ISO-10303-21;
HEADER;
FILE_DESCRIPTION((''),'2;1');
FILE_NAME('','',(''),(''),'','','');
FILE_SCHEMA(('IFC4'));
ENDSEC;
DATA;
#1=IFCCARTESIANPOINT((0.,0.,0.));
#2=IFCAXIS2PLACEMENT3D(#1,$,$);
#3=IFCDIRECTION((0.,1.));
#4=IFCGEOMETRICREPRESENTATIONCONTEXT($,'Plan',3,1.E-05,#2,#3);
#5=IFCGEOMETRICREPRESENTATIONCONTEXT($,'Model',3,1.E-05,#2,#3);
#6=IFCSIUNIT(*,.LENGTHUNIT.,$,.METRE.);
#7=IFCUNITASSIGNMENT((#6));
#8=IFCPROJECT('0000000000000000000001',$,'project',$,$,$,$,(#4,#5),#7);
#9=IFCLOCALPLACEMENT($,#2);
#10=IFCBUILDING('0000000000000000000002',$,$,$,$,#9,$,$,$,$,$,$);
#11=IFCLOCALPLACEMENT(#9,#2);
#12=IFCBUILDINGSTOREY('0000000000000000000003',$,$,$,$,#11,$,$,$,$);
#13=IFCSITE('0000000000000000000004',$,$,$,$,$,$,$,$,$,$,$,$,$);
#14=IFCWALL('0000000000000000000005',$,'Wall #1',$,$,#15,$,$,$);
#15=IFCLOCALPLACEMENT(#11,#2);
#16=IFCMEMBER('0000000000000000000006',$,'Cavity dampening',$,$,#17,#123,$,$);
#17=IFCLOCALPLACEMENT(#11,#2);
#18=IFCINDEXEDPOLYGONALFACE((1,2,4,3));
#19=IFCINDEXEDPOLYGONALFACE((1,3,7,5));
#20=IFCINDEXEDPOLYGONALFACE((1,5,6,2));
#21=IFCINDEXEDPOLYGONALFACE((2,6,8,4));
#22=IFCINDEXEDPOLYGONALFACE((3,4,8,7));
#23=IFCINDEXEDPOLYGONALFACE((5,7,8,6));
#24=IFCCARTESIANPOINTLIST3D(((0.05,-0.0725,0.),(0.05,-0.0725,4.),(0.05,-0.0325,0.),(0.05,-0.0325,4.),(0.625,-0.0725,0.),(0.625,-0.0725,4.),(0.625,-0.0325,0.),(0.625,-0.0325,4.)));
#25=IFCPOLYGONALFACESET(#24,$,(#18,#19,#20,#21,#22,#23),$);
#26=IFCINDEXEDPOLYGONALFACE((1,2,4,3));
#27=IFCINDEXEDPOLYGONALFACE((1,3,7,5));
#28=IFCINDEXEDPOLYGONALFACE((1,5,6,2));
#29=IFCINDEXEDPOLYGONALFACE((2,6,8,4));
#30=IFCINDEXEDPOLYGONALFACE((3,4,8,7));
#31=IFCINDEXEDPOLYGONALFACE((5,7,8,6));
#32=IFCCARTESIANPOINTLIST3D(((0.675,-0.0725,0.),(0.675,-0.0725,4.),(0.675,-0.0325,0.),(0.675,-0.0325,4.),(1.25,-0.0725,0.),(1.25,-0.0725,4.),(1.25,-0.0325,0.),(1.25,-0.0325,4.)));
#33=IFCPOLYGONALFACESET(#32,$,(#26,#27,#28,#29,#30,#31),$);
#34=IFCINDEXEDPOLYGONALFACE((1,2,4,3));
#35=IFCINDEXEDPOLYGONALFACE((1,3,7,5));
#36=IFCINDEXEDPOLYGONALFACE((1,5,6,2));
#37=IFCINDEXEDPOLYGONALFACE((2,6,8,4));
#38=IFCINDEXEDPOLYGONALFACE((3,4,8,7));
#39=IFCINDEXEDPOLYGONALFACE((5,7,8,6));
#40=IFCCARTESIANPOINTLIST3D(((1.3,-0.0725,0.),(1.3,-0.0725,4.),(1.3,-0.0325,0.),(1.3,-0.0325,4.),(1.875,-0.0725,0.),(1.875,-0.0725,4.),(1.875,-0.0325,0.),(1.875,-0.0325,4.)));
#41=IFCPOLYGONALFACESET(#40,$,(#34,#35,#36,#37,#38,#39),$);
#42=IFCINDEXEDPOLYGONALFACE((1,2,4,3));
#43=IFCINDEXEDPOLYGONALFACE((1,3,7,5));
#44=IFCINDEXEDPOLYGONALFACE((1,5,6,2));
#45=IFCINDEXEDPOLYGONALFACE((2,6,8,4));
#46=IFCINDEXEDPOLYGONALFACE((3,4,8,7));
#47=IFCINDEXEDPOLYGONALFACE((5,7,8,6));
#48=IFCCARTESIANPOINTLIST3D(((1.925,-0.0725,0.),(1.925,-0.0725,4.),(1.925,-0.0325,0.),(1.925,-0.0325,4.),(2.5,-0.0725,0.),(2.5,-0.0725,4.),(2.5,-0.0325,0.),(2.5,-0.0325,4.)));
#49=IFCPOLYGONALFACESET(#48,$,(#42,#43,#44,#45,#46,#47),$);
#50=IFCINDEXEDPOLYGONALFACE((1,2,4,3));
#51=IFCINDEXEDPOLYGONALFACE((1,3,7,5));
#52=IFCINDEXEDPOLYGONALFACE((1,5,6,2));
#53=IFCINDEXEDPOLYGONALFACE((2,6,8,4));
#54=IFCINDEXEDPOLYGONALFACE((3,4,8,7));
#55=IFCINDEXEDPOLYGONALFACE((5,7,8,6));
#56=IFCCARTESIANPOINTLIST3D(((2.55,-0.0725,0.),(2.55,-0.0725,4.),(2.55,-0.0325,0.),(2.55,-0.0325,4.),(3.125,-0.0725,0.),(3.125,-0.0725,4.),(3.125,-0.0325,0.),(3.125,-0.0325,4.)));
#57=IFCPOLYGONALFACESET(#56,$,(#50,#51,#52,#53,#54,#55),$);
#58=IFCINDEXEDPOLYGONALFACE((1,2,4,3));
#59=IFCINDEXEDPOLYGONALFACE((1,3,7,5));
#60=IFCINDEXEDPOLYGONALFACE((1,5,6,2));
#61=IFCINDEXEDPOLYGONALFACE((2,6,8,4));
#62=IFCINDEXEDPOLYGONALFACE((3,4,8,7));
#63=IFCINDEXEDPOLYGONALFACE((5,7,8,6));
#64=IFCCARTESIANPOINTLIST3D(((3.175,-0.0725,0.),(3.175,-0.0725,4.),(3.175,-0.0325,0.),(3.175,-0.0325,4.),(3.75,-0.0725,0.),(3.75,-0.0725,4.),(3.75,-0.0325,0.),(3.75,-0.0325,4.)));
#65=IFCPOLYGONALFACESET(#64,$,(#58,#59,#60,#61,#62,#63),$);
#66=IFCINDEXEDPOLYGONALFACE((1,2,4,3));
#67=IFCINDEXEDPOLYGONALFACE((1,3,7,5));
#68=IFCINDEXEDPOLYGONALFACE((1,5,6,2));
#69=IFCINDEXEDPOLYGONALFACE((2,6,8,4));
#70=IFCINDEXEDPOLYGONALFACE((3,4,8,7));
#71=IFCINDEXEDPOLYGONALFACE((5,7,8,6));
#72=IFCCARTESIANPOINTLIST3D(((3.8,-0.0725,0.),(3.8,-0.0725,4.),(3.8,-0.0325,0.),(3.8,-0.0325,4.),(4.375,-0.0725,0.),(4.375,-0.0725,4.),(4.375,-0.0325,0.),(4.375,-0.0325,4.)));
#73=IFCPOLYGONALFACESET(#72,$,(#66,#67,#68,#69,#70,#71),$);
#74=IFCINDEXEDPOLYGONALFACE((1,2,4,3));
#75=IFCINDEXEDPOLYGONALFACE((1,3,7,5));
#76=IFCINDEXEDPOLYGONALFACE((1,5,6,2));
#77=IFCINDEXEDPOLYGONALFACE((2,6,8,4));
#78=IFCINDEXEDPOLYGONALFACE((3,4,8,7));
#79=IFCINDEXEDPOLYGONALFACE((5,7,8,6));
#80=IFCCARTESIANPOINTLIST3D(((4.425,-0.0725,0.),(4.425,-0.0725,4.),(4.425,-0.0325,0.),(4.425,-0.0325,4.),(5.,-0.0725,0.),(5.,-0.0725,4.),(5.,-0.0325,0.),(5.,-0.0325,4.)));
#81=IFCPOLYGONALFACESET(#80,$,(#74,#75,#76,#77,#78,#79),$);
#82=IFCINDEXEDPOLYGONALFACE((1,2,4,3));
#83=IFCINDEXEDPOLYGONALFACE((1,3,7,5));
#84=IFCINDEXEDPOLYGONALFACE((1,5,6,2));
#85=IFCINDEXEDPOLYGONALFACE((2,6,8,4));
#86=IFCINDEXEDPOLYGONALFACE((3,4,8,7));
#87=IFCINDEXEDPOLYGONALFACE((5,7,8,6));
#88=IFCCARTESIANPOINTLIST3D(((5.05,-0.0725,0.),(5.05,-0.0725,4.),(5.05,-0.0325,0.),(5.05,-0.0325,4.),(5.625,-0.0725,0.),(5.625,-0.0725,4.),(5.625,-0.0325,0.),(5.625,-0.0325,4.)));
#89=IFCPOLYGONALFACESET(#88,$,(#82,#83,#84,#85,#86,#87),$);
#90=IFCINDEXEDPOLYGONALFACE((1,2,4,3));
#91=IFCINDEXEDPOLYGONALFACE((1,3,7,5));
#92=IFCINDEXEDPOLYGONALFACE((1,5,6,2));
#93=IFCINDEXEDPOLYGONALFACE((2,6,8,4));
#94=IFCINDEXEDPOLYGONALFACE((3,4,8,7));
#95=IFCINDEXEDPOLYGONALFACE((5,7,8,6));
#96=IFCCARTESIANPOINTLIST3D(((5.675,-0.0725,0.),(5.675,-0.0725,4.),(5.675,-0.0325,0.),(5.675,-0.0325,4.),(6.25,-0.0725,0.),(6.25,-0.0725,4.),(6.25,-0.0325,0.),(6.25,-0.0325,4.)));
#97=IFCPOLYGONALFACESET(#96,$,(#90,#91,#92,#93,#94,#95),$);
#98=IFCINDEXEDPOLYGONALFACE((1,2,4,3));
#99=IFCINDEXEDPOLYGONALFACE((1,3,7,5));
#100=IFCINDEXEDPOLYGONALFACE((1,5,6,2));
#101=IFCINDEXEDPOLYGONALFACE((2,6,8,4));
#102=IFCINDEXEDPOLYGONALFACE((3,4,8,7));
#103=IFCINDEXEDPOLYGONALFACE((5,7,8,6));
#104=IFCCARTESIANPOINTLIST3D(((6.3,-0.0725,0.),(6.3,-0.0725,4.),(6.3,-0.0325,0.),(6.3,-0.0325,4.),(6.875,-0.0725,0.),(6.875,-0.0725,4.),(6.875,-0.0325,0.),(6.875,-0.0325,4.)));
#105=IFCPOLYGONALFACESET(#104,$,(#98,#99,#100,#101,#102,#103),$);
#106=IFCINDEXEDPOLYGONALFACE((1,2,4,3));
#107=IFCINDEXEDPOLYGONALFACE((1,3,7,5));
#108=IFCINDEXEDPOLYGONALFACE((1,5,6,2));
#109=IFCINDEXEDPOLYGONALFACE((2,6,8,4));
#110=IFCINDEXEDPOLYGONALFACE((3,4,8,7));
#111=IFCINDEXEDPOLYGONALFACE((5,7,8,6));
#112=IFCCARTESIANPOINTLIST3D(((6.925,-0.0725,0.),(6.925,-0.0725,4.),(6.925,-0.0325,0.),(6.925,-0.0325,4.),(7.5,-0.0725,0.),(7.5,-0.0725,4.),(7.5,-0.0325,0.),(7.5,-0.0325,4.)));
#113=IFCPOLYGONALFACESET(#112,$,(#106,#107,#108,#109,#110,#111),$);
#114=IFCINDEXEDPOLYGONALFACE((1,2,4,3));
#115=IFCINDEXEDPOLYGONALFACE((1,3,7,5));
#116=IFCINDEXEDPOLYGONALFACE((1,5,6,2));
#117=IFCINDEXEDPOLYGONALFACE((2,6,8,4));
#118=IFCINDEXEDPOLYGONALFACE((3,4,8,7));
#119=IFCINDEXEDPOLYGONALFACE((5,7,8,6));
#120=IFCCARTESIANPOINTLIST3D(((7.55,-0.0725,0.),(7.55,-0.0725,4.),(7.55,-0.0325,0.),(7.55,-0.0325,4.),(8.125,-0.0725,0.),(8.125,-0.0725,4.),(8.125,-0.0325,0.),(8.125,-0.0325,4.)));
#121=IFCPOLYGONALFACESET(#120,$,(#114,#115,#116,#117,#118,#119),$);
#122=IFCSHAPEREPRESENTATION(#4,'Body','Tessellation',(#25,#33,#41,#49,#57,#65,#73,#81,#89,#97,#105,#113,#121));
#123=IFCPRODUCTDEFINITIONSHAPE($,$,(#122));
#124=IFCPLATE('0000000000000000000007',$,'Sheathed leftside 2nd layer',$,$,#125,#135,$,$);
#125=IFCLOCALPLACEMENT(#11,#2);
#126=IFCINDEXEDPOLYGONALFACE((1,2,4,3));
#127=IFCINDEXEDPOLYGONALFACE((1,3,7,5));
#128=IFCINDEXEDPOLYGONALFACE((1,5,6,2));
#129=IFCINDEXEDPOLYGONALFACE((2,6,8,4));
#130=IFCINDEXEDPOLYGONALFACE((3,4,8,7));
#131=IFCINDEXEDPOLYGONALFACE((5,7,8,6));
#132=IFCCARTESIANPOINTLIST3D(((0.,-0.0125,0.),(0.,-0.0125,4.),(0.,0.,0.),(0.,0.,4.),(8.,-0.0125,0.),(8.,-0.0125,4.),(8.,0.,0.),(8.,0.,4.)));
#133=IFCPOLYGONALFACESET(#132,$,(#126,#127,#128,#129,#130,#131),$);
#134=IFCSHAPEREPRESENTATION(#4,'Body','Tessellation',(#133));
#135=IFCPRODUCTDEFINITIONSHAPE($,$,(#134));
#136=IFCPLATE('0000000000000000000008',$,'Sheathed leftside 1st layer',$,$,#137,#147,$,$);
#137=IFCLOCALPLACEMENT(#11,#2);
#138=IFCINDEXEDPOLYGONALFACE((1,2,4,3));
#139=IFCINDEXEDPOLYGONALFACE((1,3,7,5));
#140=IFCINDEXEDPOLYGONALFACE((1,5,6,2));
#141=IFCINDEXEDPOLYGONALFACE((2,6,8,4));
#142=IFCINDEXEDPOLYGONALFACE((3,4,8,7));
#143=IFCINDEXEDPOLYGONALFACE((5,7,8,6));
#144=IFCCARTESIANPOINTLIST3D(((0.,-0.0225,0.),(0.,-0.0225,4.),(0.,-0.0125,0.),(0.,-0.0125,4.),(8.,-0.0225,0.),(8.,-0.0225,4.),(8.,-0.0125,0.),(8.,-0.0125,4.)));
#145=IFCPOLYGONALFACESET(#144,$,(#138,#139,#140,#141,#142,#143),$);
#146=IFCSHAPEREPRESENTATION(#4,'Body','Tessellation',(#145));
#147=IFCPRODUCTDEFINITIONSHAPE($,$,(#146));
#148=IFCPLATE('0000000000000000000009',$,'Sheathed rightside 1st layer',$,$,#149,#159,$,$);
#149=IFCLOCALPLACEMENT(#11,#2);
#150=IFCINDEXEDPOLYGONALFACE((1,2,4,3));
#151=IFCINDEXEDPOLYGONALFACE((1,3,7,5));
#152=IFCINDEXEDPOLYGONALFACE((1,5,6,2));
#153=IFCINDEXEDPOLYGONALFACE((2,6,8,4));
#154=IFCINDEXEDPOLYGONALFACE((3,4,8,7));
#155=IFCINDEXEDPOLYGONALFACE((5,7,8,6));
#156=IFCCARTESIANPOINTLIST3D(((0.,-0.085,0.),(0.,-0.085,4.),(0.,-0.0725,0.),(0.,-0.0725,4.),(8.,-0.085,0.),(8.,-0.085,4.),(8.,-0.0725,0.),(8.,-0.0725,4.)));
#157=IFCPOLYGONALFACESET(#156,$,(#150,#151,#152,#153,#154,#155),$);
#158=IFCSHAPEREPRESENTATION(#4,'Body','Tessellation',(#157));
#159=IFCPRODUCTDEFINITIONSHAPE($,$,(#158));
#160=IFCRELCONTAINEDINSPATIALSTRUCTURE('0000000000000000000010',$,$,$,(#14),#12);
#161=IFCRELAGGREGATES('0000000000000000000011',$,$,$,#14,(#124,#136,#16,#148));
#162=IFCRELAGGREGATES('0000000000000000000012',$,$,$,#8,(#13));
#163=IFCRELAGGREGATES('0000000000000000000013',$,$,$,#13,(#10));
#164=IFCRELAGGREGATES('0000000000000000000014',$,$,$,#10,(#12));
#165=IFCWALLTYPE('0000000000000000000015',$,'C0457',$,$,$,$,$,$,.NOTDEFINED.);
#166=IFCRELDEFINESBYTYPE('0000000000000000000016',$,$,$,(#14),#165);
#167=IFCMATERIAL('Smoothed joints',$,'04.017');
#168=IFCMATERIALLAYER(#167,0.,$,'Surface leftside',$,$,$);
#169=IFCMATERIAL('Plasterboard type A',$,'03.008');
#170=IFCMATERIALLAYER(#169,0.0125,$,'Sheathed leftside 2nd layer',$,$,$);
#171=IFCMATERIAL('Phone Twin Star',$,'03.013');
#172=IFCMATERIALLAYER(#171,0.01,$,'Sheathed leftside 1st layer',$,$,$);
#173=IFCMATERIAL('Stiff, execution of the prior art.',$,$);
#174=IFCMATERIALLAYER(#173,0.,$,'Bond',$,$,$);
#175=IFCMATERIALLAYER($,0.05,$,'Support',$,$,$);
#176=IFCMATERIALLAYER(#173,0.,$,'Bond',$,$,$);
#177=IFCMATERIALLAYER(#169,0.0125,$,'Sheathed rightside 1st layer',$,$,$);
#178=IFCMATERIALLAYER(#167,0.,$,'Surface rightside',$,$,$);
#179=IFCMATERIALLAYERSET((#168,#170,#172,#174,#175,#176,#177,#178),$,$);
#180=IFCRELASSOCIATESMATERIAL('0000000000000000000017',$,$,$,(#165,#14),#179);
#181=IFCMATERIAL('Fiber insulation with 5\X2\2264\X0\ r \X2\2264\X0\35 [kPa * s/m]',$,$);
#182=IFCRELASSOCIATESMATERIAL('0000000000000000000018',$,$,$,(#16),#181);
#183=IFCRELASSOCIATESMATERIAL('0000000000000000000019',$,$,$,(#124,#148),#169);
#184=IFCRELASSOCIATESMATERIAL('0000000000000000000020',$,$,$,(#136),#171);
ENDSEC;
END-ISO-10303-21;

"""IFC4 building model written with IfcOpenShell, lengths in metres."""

from ifc_helpers import new_model, si_unit, direction, frame, frame_2d, origin, origin_with_axes, place, context, project, spatial, rectangle, extrude, material, layer, layer_set, type_object, element, aggregate, save


model = new_model("IFC4")

# Units and contexts
plan_context = context("Plan", 3, precision=1e-05, world=origin(), true_north=direction((0.0, 1.0)))
model_context = context("Model", 3, precision=1e-05, world=origin(), true_north=direction((0.0, 1.0)))
ifc_project = project(units=[si_unit("LENGTHUNIT", "METRE")], contexts=[plan_context, model_context])

# Site, building, storey
site = spatial("IfcSite", under=ifc_project)
building_placement = place(None, origin())
building = spatial("IfcBuilding", under=site, at=building_placement)
storey_placement = place(building_placement, origin())
storey = spatial("IfcBuildingStorey", under=building, at=storey_placement)

# Wall, member, plates
ifc_material_1 = material(Name="Smoothed joints", Category="04.017")
ifc_layer_1 = layer(ifc_material_1, 0.0, Name="Surface leftside")
ifc_material_2 = material(Name="Plasterboard type A", Category="03.008")
ifc_layer_2 = layer(ifc_material_2, 0.0125, Name="Sheathed leftside 2nd layer")
ifc_material_3 = material(Name="Phone Twin Star", Category="03.013")
ifc_layer_3 = layer(ifc_material_3, 0.01, Name="Sheathed leftside 1st layer")
ifc_material_4 = material(Name="Stiff, execution of the prior art.")
ifc_layer_4 = layer(ifc_material_4, 0.0, Name="Bond")
ifc_layer_5 = layer(None, 0.05, Name="Support")
ifc_layer_6 = layer(ifc_material_4, 0.0, Name="Bond")
ifc_layer_7 = layer(ifc_material_2, 0.0125, Name="Sheathed rightside 1st layer")
ifc_layer_8 = layer(ifc_material_1, 0.0, Name="Surface rightside")
ifc_layer_set = layer_set([ifc_layer_1, ifc_layer_2, ifc_layer_3, ifc_layer_4, ifc_layer_5, ifc_layer_6, ifc_layer_7, ifc_layer_8])
wall_type = type_object("IfcWallType", Name="C0457", PredefinedType="NOTDEFINED", material=ifc_layer_set)
wall_placement = place(None, frame((0.0, 0.0, 0.0), z_axis=(0.0, -1.0, 0.0), x_axis=(1.0, 0.0, 0.0)))
wall = element("IfcWall", 1, at=wall_placement, inside=storey, type_object=wall_type, material=ifc_layer_set, Name="Wall #1")
ifc_material_5 = material(Name="Fiber insulation with 5≤ r ≤35 [kPa * s/m]")
member_1_placement = place(wall_placement, origin())
member_1 = element("IfcMember", 2, at=member_1_placement, material=ifc_material_5, Name="Cavity dampening", context=plan_context, shape_type="SweptSolid", body=[
    extrude(rectangle(XDim=0.575, YDim=0.04, at=frame_2d((0.2875, 0.02), x_axis=(1.0, 0.0))), frame((0.05, 4.0, 0.0325), z_axis=(0.0, -1.0, 0.0), x_axis=(1.0, 0.0, 0.0)), (0.0, 0.0, 1.0), 4.0),
    extrude(rectangle(XDim=0.575, YDim=0.04, at=frame_2d((0.2875, 0.02), x_axis=(1.0, 0.0))), frame((0.675, 4.0, 0.0325), z_axis=(0.0, -1.0, 0.0), x_axis=(1.0, 0.0, 0.0)), (0.0, 0.0, 1.0), 4.0),
    extrude(rectangle(XDim=0.575, YDim=0.04, at=frame_2d((0.2875, 0.02), x_axis=(1.0, 0.0))), frame((1.3, 4.0, 0.0325), z_axis=(0.0, -1.0, 0.0), x_axis=(1.0, 0.0, 0.0)), (0.0, 0.0, 1.0), 4.0),
    extrude(rectangle(XDim=0.575, YDim=0.04, at=frame_2d((0.2875, 0.02), x_axis=(1.0, 0.0))), frame((1.925, 4.0, 0.0325), z_axis=(0.0, -1.0, 0.0), x_axis=(1.0, 0.0, 0.0)), (0.0, 0.0, 1.0), 4.0),
    extrude(rectangle(XDim=0.575, YDim=0.04, at=frame_2d((0.2875, 0.02), x_axis=(1.0, 0.0))), frame((2.55, 4.0, 0.0325), z_axis=(0.0, -1.0, 0.0), x_axis=(1.0, 0.0, 0.0)), (0.0, 0.0, 1.0), 4.0),
    extrude(rectangle(XDim=0.575, YDim=0.04, at=frame_2d((0.2875, 0.02), x_axis=(1.0, 0.0))), frame((3.175, 4.0, 0.0325), z_axis=(0.0, -1.0, 0.0), x_axis=(1.0, 0.0, 0.0)), (0.0, 0.0, 1.0), 4.0),
    extrude(rectangle(XDim=0.575, YDim=0.04, at=frame_2d((0.2875, 0.02), x_axis=(1.0, 0.0))), frame((3.8, 4.0, 0.0325), z_axis=(0.0, -1.0, 0.0), x_axis=(1.0, 0.0, 0.0)), (0.0, 0.0, 1.0), 4.0),
    extrude(rectangle(XDim=0.575, YDim=0.04, at=frame_2d((0.2875, 0.02), x_axis=(1.0, 0.0))), frame((4.425, 4.0, 0.0325), z_axis=(0.0, -1.0, 0.0), x_axis=(1.0, 0.0, 0.0)), (0.0, 0.0, 1.0), 4.0),
    extrude(rectangle(XDim=0.575, YDim=0.04, at=frame_2d((0.2875, 0.02), x_axis=(1.0, 0.0))), frame((5.05, 4.0, 0.0325), z_axis=(0.0, -1.0, 0.0), x_axis=(1.0, 0.0, 0.0)), (0.0, 0.0, 1.0), 4.0),
    extrude(rectangle(XDim=0.575, YDim=0.04, at=frame_2d((0.2875, 0.02), x_axis=(1.0, 0.0))), frame((5.675, 4.0, 0.0325), z_axis=(0.0, -1.0, 0.0), x_axis=(1.0, 0.0, 0.0)), (0.0, 0.0, 1.0), 4.0),
    extrude(rectangle(XDim=0.575, YDim=0.04, at=frame_2d((0.2875, 0.02), x_axis=(1.0, 0.0))), frame((6.3, 4.0, 0.0325), z_axis=(0.0, -1.0, 0.0), x_axis=(1.0, 0.0, 0.0)), (0.0, 0.0, 1.0), 4.0),
    extrude(rectangle(XDim=0.575, YDim=0.04, at=frame_2d((0.2875, 0.02), x_axis=(1.0, 0.0))), frame((6.925, 4.0, 0.0325), z_axis=(0.0, -1.0, 0.0), x_axis=(1.0, 0.0, 0.0)), (0.0, 0.0, 1.0), 4.0),
    extrude(rectangle(XDim=0.575, YDim=0.04, at=frame_2d((0.2875, 0.02), x_axis=(1.0, 0.0))), frame((7.55, 4.0, 0.0325), z_axis=(0.0, -1.0, 0.0), x_axis=(1.0, 0.0, 0.0)), (0.0, 0.0, 1.0), 4.0),
])
plate_1_placement = place(wall_placement, origin())
plate_1 = element("IfcPlate", 3, at=plate_1_placement, material=ifc_material_2, Name="Sheathed leftside 2nd layer", context=plan_context, shape_type="SweptSolid", body=[
    extrude(rectangle(XDim=8.0, YDim=4.0, at=frame_2d((4.0, 2.0), x_axis=(1.0, 0.0))), origin_with_axes(), (0.0, 0.0, 1.0), 0.0125),
])
plate_2_placement = place(wall_placement, origin())
plate_2 = element("IfcPlate", 4, at=plate_2_placement, material=ifc_material_3, Name="Sheathed leftside 1st layer", context=plan_context, shape_type="SweptSolid", body=[
    extrude(rectangle(XDim=8.0, YDim=4.0, at=frame_2d((4.0, 2.0), x_axis=(1.0, 0.0))), frame((0.0, 0.0, 0.0125), z_axis=(0.0, 0.0, 1.0), x_axis=(1.0, 0.0, 0.0)), (0.0, 0.0, 1.0), 0.01),
])
plate_3_placement = place(wall_placement, origin())
plate_3 = element("IfcPlate", 5, at=plate_3_placement, material=ifc_material_2, Name="Sheathed rightside 1st layer", context=plan_context, shape_type="SweptSolid", body=[
    extrude(rectangle(XDim=8.0, YDim=4.0, at=frame_2d((4.0, 2.0), x_axis=(1.0, 0.0))), frame((0.0, 0.0, 0.0725), z_axis=(0.0, 0.0, 1.0), x_axis=(1.0, 0.0, 0.0)), (0.0, 0.0, 1.0), 0.0125),
])
aggregate(wall, [plate_1, plate_2, member_1, plate_3])

save(model, "model.ifc")
